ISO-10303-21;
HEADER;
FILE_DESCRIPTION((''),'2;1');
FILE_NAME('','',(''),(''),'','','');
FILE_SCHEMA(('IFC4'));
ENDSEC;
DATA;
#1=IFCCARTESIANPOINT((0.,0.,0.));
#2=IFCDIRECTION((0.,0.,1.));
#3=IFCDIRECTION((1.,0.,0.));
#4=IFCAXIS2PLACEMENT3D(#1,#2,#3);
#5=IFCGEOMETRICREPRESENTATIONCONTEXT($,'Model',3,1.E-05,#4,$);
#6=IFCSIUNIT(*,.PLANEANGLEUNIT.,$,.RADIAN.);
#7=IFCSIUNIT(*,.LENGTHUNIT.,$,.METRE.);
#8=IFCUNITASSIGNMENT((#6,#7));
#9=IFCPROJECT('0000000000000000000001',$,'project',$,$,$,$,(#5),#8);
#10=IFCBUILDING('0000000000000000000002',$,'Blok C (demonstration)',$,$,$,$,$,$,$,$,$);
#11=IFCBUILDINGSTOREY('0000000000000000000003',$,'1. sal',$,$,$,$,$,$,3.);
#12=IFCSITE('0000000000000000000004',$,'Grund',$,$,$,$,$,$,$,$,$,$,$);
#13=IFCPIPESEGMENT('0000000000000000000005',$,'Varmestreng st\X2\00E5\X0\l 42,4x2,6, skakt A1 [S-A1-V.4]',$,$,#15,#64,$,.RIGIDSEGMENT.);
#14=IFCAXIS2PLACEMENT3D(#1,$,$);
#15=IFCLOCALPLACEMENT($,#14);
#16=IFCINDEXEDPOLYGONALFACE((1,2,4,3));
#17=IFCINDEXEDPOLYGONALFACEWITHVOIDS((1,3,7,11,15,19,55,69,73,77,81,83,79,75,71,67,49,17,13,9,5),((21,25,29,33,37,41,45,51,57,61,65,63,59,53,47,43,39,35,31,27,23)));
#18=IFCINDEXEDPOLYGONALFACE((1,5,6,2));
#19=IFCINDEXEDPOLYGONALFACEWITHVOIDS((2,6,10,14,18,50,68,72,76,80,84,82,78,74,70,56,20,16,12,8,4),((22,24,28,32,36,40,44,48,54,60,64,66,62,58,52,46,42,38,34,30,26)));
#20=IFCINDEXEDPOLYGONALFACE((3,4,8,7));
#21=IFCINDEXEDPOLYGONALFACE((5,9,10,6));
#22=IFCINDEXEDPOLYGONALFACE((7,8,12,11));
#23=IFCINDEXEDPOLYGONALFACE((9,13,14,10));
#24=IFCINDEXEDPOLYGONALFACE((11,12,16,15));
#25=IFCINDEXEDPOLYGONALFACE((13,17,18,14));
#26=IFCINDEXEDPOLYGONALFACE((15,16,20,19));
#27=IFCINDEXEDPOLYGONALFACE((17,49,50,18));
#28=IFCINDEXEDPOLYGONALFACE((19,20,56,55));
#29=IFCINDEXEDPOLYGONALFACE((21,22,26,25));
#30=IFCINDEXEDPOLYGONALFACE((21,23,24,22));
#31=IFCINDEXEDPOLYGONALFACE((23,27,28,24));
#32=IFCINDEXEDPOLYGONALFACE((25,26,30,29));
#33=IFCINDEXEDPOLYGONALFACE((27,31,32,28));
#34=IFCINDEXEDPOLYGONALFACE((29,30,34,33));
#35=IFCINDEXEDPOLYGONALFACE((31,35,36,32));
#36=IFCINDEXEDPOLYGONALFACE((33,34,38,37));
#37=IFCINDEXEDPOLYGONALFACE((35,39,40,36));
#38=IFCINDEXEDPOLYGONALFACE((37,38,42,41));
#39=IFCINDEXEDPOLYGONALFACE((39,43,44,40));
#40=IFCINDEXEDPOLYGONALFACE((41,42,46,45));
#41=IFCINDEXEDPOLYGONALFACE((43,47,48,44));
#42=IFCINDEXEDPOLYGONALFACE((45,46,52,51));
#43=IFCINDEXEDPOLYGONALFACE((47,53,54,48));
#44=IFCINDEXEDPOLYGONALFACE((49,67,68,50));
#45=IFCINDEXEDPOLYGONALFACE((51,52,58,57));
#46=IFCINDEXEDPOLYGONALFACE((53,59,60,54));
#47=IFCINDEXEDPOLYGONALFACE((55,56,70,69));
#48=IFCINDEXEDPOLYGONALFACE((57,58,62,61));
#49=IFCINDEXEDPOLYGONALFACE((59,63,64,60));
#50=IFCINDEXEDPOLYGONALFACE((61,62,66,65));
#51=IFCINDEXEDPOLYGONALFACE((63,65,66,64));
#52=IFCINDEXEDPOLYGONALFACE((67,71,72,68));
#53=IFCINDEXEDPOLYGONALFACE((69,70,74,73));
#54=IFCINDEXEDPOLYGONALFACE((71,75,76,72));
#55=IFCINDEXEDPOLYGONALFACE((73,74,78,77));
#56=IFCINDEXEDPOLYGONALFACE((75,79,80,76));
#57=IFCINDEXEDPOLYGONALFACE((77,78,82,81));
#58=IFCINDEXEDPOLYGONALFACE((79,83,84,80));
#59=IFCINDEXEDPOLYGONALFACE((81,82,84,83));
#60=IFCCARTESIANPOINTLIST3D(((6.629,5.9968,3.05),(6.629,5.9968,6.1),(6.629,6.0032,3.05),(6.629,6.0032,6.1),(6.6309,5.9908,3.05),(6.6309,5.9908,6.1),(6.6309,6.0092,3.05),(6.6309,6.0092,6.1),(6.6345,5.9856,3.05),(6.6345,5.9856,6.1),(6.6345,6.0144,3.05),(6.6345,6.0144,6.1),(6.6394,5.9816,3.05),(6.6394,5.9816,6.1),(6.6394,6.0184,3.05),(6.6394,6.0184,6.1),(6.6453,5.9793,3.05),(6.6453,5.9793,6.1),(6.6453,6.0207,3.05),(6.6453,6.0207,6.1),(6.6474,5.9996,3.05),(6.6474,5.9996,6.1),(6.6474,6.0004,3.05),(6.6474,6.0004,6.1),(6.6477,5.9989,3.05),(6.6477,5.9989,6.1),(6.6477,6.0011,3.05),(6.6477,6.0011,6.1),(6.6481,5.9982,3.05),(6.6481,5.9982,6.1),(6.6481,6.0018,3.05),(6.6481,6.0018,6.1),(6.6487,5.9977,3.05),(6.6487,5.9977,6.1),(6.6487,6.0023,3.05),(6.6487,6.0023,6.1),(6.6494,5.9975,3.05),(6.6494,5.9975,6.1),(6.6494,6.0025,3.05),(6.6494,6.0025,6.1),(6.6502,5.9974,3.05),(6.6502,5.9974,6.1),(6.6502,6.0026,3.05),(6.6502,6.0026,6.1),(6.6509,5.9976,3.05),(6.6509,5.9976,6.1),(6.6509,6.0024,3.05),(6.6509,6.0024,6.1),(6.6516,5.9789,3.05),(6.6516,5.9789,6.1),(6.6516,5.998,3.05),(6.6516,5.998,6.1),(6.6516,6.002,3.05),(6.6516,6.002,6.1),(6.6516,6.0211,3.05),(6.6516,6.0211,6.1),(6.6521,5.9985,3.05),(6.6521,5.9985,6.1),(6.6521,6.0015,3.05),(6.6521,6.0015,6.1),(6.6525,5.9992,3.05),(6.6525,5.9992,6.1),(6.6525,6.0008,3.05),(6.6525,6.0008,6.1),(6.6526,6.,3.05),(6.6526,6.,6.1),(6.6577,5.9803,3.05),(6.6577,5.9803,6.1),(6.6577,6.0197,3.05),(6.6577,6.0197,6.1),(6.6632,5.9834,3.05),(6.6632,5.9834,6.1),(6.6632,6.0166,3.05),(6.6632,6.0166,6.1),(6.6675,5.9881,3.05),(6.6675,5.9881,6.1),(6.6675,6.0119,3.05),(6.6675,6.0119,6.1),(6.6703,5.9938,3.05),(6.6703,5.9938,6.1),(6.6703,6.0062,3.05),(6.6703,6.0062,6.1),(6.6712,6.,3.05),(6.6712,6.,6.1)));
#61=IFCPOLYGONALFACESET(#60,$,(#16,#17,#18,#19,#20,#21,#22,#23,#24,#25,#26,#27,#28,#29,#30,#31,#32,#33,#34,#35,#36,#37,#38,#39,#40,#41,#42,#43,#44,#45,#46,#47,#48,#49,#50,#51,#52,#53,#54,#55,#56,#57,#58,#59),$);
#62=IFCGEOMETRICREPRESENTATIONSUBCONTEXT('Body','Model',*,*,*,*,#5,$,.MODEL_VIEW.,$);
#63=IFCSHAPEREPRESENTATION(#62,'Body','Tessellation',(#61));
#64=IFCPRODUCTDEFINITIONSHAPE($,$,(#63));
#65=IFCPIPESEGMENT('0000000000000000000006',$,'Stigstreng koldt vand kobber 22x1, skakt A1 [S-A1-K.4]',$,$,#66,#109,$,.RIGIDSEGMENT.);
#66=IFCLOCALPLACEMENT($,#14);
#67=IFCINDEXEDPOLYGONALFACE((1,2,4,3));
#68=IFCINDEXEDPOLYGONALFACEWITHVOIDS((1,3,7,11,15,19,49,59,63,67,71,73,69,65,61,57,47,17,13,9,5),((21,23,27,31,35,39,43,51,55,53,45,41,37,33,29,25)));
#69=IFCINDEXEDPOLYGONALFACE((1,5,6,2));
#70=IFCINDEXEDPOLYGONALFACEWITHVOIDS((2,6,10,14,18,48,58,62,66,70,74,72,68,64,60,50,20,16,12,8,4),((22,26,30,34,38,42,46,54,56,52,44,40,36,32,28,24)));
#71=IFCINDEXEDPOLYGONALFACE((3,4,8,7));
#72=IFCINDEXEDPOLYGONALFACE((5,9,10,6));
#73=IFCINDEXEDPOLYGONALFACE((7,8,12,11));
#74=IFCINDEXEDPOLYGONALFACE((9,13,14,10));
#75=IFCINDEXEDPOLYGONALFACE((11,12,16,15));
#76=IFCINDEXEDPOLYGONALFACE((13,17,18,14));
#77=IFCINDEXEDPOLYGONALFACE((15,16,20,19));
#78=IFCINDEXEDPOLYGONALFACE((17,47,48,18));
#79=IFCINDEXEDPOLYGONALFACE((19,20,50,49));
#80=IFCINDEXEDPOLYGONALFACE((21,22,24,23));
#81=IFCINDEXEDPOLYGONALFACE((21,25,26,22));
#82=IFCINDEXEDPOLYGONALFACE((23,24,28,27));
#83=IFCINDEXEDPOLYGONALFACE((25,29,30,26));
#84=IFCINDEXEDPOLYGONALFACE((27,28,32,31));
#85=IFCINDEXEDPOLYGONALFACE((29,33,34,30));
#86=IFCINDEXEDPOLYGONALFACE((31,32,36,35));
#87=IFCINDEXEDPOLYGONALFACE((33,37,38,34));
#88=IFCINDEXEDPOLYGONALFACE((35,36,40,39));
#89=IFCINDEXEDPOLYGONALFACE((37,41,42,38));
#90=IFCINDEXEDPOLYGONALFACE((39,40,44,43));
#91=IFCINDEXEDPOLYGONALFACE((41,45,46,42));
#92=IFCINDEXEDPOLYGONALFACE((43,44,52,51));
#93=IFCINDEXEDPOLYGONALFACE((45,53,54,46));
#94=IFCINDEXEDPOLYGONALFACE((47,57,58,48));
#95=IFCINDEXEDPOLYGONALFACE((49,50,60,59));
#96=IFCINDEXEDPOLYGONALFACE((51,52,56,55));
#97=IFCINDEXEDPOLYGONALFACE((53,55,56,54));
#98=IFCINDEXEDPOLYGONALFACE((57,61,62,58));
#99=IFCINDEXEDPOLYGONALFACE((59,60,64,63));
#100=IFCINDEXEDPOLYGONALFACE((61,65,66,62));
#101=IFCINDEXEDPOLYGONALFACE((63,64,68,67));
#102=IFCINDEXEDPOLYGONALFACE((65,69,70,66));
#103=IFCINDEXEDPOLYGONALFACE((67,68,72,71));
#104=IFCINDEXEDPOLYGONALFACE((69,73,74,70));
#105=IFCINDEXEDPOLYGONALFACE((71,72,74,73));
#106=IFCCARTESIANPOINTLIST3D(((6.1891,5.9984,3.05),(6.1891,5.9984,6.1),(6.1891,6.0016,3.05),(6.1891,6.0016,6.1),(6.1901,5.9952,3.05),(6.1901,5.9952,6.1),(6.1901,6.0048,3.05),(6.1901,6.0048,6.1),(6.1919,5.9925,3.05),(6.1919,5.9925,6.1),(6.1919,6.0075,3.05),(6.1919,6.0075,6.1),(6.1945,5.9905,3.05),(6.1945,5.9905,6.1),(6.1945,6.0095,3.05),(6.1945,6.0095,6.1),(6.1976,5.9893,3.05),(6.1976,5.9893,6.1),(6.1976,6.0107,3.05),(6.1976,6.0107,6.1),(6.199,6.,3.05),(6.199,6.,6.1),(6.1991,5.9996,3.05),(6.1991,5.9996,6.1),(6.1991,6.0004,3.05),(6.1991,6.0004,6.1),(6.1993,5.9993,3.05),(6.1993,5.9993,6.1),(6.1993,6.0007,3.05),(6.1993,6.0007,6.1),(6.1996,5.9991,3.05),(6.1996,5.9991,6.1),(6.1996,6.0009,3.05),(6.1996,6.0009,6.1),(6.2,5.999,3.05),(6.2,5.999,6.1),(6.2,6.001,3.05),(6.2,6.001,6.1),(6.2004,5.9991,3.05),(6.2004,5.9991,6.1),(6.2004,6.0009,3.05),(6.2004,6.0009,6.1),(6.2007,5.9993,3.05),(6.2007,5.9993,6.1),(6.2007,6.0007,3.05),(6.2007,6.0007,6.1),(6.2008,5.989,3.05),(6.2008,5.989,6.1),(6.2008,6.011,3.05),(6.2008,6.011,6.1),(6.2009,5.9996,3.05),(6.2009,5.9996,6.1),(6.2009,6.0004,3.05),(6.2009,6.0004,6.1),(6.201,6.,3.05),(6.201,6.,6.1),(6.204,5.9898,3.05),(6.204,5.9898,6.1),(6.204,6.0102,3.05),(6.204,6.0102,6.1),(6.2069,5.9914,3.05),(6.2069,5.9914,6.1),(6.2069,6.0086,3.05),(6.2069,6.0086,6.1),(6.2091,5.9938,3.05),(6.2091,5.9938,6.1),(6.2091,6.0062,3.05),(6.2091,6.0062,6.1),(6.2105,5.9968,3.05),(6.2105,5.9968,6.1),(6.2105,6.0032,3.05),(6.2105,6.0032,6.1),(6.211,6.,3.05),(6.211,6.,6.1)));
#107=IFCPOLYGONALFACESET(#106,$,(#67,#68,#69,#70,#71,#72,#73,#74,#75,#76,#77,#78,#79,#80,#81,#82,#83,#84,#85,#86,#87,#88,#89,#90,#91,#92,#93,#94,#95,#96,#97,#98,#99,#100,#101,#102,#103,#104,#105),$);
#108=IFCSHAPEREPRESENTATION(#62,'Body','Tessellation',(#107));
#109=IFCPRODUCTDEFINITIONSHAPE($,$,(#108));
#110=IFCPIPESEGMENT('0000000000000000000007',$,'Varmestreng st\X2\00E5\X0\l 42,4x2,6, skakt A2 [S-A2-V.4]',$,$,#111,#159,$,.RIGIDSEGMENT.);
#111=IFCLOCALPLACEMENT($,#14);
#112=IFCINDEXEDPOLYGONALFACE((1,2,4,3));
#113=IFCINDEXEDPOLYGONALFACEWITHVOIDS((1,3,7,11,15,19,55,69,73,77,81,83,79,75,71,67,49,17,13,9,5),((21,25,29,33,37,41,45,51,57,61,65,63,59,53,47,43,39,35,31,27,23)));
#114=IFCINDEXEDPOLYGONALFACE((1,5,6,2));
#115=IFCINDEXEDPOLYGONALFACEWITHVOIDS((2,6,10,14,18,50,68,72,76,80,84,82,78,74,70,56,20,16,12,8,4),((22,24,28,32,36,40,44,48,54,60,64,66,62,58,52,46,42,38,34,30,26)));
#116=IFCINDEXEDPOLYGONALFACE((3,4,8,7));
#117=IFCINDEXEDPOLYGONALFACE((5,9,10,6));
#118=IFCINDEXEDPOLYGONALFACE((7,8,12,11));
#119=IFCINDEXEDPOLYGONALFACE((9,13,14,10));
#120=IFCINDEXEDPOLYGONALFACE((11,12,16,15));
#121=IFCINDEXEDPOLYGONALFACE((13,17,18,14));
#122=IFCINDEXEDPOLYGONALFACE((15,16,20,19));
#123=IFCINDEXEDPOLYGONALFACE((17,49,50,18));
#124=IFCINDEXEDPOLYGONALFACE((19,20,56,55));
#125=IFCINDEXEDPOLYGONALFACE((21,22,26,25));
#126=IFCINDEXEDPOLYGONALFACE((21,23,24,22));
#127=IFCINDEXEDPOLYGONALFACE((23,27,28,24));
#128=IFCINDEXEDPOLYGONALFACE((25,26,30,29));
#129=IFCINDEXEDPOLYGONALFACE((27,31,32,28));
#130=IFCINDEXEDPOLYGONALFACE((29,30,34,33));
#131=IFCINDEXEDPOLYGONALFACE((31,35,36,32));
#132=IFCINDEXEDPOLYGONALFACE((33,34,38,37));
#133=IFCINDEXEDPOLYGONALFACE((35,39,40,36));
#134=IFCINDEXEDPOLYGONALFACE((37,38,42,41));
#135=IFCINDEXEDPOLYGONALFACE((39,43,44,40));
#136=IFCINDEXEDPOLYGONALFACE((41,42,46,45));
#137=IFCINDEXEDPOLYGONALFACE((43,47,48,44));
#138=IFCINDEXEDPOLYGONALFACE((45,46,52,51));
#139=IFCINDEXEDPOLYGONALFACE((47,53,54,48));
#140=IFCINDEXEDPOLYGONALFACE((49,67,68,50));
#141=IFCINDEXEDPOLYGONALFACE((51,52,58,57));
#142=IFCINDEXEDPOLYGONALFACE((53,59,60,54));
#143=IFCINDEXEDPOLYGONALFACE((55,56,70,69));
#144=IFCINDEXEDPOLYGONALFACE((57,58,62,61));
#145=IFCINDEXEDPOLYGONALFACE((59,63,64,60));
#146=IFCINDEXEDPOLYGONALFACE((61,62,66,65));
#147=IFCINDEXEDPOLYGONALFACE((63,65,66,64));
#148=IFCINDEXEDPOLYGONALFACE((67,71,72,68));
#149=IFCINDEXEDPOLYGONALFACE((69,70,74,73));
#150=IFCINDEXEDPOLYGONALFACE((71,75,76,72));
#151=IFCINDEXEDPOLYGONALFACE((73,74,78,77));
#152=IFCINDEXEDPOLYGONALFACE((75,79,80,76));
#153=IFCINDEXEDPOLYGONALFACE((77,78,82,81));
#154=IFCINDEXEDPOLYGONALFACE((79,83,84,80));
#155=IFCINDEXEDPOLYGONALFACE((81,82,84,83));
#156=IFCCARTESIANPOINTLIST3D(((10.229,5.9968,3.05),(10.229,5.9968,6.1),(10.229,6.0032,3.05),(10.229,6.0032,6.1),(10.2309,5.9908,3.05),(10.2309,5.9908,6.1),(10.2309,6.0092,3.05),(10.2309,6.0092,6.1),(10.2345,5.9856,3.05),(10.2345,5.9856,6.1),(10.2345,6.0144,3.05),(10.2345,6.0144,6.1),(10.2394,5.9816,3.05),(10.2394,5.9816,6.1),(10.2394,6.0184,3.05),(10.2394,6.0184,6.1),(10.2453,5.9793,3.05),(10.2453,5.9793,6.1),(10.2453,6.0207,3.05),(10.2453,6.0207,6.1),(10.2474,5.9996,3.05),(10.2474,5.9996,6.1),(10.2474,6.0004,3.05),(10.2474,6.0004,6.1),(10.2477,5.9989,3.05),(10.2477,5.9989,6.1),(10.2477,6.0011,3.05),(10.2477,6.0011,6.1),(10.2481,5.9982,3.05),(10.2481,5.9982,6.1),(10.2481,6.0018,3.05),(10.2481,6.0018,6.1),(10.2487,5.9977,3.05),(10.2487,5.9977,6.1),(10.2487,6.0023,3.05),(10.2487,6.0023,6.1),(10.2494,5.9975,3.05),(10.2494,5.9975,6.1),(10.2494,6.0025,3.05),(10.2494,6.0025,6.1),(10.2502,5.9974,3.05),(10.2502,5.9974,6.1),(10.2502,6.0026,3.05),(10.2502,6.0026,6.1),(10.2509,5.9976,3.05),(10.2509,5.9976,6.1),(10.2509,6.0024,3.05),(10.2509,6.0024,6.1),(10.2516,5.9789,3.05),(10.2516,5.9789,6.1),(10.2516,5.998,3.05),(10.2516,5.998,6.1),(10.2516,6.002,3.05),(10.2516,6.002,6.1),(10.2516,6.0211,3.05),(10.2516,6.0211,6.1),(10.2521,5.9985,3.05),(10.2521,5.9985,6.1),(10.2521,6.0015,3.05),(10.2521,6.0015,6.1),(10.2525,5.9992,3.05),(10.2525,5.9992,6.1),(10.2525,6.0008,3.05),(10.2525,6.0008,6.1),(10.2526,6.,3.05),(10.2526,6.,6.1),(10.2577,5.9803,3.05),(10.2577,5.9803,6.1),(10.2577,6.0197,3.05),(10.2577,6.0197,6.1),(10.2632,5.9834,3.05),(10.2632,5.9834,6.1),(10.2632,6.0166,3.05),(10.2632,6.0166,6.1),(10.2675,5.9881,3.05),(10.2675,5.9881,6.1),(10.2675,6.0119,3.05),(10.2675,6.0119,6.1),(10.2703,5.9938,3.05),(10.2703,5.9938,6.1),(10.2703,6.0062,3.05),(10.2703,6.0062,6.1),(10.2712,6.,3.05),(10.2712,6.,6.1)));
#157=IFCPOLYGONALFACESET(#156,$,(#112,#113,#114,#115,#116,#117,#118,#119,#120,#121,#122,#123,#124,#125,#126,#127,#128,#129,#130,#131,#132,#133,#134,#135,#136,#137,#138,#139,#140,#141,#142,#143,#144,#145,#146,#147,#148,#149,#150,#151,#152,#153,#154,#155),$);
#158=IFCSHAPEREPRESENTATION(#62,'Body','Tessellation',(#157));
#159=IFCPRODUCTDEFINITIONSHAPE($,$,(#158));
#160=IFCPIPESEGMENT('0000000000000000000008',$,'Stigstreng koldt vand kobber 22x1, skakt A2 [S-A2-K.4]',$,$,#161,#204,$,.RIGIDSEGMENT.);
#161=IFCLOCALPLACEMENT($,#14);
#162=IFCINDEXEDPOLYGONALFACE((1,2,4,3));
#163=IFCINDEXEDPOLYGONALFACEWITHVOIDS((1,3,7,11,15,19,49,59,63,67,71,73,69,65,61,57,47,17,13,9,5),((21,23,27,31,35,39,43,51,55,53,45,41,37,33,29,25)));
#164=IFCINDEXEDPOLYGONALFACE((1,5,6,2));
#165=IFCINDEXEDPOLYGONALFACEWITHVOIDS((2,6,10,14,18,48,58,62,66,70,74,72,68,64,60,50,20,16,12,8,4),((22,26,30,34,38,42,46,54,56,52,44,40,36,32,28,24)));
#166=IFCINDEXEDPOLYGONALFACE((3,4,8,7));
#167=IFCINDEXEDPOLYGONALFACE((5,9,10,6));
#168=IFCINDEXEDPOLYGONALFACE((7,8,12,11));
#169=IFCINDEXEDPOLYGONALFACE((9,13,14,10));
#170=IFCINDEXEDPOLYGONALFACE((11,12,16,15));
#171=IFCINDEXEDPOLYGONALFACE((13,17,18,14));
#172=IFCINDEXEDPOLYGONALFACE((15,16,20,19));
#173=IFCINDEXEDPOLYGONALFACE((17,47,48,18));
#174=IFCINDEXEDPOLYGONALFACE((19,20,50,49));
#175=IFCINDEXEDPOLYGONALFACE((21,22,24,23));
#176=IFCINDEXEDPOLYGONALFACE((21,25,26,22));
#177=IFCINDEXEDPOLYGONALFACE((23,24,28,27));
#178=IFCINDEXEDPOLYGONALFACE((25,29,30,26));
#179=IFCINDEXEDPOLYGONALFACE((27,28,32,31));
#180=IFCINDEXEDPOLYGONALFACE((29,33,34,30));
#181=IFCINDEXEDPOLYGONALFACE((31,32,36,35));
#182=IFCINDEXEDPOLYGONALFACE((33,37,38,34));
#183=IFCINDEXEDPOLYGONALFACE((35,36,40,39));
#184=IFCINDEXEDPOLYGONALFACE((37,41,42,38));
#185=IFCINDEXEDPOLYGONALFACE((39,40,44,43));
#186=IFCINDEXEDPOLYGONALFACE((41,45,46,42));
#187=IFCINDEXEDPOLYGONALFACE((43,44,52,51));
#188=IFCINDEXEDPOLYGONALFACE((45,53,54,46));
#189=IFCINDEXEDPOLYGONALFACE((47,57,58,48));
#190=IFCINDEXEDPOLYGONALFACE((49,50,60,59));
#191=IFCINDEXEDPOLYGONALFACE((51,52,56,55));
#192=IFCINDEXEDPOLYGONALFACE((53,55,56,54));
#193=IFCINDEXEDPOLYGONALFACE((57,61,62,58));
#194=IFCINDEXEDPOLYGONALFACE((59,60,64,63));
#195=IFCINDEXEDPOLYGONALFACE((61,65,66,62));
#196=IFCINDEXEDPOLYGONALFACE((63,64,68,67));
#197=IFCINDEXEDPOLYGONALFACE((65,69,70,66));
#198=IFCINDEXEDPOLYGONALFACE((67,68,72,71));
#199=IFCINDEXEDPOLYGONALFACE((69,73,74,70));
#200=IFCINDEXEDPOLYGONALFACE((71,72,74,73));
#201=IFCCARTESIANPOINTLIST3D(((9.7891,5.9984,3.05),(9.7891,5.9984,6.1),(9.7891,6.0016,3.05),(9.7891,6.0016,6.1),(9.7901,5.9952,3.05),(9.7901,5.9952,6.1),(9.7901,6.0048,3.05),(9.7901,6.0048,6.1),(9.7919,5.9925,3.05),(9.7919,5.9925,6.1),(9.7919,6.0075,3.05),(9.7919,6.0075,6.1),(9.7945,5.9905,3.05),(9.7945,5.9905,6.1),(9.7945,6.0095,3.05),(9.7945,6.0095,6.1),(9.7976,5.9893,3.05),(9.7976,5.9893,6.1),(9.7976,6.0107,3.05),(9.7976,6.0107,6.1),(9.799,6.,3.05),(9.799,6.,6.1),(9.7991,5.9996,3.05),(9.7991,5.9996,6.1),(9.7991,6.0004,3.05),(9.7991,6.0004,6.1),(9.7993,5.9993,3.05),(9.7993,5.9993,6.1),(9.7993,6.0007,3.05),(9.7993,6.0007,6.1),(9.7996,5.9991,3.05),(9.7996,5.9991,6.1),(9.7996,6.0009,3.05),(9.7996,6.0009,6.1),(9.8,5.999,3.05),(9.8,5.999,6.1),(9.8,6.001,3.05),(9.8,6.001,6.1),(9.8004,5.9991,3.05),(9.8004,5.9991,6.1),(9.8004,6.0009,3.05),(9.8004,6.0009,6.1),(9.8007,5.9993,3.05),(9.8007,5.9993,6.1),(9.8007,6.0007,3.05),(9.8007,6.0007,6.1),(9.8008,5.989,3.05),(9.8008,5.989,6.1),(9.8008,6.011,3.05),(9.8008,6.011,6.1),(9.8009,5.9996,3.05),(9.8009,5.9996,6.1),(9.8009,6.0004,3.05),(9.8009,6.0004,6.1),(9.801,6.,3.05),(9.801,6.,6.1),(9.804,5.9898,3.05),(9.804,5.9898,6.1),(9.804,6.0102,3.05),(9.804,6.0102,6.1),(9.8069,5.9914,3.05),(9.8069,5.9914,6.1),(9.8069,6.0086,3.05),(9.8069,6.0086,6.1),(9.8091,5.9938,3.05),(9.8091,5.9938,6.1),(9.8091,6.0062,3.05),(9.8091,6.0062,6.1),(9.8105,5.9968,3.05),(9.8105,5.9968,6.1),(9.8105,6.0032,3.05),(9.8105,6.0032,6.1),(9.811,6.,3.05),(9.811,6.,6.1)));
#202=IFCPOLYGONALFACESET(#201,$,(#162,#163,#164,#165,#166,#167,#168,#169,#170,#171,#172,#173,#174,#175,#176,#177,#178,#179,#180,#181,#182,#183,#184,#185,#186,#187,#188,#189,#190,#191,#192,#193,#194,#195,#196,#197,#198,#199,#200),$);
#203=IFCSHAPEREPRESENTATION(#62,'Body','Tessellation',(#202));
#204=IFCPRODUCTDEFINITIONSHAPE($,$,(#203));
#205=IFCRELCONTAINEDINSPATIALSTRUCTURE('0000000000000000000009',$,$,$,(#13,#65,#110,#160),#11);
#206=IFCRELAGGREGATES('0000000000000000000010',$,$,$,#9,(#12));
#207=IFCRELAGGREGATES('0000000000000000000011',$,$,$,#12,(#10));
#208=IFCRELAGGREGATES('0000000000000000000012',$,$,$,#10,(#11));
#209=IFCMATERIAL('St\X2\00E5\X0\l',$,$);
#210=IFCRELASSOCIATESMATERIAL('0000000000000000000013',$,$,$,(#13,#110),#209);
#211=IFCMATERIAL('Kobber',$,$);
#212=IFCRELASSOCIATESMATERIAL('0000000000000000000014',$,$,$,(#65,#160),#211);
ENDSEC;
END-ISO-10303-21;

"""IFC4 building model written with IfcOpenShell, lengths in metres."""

from ifc_helpers import new_model, si_unit, frame, origin_with_axes, place, context, subcontext, project, spatial, hollow_circle, extrude, material, element, save


model = new_model("IFC4")

# Units and contexts
model_context = context("Model", 3, precision=1e-05, world=origin_with_axes())
body_context = subcontext(model_context, "Body", "Model", "MODEL_VIEW")
ifc_project = project(units=[si_unit("PLANEANGLEUNIT", "RADIAN"), si_unit("LENGTHUNIT", "METRE")], contexts=[model_context])

# Site, building, storey
site = spatial("IfcSite", under=ifc_project, Name="Grund")
building = spatial("IfcBuilding", under=site, Name="Blok C (demonstration)")
storey = spatial("IfcBuildingStorey", under=building, Name="1. sal", Elevation=3.0)

# Pipe segments
ifc_material_1 = material(Name="Stål")
pipe_segment_1_placement = place(None, origin_with_axes())
element("IfcPipeSegment", 1, at=pipe_segment_1_placement, inside=storey, material=ifc_material_1, Name="Varmestreng stål 42,4x2,6, skakt A1 [S-A1-V.4]", PredefinedType="RIGIDSEGMENT", context=body_context, shape_type="SweptSolid", body=[
    extrude(hollow_circle(Radius=0.0212, WallThickness=0.0186), frame((6.65, 6.0, 3.05), z_axis=(0.0, 0.0, 1.0), x_axis=(1.0, 0.0, 0.0)), (0.0, 0.0, 1.0), 3.05),
])
ifc_material_2 = material(Name="Kobber")
pipe_segment_2_placement = place(None, origin_with_axes())
element("IfcPipeSegment", 2, at=pipe_segment_2_placement, inside=storey, material=ifc_material_2, Name="Stigstreng koldt vand kobber 22x1, skakt A1 [S-A1-K.4]", PredefinedType="RIGIDSEGMENT", context=body_context, shape_type="SweptSolid", body=[
    extrude(hollow_circle(Radius=0.011, WallThickness=0.01), frame((6.2, 6.0, 3.05), z_axis=(0.0, 0.0, 1.0), x_axis=(1.0, 0.0, 0.0)), (0.0, 0.0, 1.0), 3.05),
])
pipe_segment_3_placement = place(None, origin_with_axes())
element("IfcPipeSegment", 3, at=pipe_segment_3_placement, inside=storey, material=ifc_material_1, Name="Varmestreng stål 42,4x2,6, skakt A2 [S-A2-V.4]", PredefinedType="RIGIDSEGMENT", context=body_context, shape_type="SweptSolid", body=[
    extrude(hollow_circle(Radius=0.0212, WallThickness=0.0186), frame((10.25, 6.0, 3.05), z_axis=(0.0, 0.0, 1.0), x_axis=(1.0, 0.0, 0.0)), (0.0, 0.0, 1.0), 3.05),
])
pipe_segment_4_placement = place(None, origin_with_axes())
element("IfcPipeSegment", 4, at=pipe_segment_4_placement, inside=storey, material=ifc_material_2, Name="Stigstreng koldt vand kobber 22x1, skakt A2 [S-A2-K.4]", PredefinedType="RIGIDSEGMENT", context=body_context, shape_type="SweptSolid", body=[
    extrude(hollow_circle(Radius=0.011, WallThickness=0.01), frame((9.8, 6.0, 3.05), z_axis=(0.0, 0.0, 1.0), x_axis=(1.0, 0.0, 0.0)), (0.0, 0.0, 1.0), 3.05),
])

save(model, "model.ifc")
